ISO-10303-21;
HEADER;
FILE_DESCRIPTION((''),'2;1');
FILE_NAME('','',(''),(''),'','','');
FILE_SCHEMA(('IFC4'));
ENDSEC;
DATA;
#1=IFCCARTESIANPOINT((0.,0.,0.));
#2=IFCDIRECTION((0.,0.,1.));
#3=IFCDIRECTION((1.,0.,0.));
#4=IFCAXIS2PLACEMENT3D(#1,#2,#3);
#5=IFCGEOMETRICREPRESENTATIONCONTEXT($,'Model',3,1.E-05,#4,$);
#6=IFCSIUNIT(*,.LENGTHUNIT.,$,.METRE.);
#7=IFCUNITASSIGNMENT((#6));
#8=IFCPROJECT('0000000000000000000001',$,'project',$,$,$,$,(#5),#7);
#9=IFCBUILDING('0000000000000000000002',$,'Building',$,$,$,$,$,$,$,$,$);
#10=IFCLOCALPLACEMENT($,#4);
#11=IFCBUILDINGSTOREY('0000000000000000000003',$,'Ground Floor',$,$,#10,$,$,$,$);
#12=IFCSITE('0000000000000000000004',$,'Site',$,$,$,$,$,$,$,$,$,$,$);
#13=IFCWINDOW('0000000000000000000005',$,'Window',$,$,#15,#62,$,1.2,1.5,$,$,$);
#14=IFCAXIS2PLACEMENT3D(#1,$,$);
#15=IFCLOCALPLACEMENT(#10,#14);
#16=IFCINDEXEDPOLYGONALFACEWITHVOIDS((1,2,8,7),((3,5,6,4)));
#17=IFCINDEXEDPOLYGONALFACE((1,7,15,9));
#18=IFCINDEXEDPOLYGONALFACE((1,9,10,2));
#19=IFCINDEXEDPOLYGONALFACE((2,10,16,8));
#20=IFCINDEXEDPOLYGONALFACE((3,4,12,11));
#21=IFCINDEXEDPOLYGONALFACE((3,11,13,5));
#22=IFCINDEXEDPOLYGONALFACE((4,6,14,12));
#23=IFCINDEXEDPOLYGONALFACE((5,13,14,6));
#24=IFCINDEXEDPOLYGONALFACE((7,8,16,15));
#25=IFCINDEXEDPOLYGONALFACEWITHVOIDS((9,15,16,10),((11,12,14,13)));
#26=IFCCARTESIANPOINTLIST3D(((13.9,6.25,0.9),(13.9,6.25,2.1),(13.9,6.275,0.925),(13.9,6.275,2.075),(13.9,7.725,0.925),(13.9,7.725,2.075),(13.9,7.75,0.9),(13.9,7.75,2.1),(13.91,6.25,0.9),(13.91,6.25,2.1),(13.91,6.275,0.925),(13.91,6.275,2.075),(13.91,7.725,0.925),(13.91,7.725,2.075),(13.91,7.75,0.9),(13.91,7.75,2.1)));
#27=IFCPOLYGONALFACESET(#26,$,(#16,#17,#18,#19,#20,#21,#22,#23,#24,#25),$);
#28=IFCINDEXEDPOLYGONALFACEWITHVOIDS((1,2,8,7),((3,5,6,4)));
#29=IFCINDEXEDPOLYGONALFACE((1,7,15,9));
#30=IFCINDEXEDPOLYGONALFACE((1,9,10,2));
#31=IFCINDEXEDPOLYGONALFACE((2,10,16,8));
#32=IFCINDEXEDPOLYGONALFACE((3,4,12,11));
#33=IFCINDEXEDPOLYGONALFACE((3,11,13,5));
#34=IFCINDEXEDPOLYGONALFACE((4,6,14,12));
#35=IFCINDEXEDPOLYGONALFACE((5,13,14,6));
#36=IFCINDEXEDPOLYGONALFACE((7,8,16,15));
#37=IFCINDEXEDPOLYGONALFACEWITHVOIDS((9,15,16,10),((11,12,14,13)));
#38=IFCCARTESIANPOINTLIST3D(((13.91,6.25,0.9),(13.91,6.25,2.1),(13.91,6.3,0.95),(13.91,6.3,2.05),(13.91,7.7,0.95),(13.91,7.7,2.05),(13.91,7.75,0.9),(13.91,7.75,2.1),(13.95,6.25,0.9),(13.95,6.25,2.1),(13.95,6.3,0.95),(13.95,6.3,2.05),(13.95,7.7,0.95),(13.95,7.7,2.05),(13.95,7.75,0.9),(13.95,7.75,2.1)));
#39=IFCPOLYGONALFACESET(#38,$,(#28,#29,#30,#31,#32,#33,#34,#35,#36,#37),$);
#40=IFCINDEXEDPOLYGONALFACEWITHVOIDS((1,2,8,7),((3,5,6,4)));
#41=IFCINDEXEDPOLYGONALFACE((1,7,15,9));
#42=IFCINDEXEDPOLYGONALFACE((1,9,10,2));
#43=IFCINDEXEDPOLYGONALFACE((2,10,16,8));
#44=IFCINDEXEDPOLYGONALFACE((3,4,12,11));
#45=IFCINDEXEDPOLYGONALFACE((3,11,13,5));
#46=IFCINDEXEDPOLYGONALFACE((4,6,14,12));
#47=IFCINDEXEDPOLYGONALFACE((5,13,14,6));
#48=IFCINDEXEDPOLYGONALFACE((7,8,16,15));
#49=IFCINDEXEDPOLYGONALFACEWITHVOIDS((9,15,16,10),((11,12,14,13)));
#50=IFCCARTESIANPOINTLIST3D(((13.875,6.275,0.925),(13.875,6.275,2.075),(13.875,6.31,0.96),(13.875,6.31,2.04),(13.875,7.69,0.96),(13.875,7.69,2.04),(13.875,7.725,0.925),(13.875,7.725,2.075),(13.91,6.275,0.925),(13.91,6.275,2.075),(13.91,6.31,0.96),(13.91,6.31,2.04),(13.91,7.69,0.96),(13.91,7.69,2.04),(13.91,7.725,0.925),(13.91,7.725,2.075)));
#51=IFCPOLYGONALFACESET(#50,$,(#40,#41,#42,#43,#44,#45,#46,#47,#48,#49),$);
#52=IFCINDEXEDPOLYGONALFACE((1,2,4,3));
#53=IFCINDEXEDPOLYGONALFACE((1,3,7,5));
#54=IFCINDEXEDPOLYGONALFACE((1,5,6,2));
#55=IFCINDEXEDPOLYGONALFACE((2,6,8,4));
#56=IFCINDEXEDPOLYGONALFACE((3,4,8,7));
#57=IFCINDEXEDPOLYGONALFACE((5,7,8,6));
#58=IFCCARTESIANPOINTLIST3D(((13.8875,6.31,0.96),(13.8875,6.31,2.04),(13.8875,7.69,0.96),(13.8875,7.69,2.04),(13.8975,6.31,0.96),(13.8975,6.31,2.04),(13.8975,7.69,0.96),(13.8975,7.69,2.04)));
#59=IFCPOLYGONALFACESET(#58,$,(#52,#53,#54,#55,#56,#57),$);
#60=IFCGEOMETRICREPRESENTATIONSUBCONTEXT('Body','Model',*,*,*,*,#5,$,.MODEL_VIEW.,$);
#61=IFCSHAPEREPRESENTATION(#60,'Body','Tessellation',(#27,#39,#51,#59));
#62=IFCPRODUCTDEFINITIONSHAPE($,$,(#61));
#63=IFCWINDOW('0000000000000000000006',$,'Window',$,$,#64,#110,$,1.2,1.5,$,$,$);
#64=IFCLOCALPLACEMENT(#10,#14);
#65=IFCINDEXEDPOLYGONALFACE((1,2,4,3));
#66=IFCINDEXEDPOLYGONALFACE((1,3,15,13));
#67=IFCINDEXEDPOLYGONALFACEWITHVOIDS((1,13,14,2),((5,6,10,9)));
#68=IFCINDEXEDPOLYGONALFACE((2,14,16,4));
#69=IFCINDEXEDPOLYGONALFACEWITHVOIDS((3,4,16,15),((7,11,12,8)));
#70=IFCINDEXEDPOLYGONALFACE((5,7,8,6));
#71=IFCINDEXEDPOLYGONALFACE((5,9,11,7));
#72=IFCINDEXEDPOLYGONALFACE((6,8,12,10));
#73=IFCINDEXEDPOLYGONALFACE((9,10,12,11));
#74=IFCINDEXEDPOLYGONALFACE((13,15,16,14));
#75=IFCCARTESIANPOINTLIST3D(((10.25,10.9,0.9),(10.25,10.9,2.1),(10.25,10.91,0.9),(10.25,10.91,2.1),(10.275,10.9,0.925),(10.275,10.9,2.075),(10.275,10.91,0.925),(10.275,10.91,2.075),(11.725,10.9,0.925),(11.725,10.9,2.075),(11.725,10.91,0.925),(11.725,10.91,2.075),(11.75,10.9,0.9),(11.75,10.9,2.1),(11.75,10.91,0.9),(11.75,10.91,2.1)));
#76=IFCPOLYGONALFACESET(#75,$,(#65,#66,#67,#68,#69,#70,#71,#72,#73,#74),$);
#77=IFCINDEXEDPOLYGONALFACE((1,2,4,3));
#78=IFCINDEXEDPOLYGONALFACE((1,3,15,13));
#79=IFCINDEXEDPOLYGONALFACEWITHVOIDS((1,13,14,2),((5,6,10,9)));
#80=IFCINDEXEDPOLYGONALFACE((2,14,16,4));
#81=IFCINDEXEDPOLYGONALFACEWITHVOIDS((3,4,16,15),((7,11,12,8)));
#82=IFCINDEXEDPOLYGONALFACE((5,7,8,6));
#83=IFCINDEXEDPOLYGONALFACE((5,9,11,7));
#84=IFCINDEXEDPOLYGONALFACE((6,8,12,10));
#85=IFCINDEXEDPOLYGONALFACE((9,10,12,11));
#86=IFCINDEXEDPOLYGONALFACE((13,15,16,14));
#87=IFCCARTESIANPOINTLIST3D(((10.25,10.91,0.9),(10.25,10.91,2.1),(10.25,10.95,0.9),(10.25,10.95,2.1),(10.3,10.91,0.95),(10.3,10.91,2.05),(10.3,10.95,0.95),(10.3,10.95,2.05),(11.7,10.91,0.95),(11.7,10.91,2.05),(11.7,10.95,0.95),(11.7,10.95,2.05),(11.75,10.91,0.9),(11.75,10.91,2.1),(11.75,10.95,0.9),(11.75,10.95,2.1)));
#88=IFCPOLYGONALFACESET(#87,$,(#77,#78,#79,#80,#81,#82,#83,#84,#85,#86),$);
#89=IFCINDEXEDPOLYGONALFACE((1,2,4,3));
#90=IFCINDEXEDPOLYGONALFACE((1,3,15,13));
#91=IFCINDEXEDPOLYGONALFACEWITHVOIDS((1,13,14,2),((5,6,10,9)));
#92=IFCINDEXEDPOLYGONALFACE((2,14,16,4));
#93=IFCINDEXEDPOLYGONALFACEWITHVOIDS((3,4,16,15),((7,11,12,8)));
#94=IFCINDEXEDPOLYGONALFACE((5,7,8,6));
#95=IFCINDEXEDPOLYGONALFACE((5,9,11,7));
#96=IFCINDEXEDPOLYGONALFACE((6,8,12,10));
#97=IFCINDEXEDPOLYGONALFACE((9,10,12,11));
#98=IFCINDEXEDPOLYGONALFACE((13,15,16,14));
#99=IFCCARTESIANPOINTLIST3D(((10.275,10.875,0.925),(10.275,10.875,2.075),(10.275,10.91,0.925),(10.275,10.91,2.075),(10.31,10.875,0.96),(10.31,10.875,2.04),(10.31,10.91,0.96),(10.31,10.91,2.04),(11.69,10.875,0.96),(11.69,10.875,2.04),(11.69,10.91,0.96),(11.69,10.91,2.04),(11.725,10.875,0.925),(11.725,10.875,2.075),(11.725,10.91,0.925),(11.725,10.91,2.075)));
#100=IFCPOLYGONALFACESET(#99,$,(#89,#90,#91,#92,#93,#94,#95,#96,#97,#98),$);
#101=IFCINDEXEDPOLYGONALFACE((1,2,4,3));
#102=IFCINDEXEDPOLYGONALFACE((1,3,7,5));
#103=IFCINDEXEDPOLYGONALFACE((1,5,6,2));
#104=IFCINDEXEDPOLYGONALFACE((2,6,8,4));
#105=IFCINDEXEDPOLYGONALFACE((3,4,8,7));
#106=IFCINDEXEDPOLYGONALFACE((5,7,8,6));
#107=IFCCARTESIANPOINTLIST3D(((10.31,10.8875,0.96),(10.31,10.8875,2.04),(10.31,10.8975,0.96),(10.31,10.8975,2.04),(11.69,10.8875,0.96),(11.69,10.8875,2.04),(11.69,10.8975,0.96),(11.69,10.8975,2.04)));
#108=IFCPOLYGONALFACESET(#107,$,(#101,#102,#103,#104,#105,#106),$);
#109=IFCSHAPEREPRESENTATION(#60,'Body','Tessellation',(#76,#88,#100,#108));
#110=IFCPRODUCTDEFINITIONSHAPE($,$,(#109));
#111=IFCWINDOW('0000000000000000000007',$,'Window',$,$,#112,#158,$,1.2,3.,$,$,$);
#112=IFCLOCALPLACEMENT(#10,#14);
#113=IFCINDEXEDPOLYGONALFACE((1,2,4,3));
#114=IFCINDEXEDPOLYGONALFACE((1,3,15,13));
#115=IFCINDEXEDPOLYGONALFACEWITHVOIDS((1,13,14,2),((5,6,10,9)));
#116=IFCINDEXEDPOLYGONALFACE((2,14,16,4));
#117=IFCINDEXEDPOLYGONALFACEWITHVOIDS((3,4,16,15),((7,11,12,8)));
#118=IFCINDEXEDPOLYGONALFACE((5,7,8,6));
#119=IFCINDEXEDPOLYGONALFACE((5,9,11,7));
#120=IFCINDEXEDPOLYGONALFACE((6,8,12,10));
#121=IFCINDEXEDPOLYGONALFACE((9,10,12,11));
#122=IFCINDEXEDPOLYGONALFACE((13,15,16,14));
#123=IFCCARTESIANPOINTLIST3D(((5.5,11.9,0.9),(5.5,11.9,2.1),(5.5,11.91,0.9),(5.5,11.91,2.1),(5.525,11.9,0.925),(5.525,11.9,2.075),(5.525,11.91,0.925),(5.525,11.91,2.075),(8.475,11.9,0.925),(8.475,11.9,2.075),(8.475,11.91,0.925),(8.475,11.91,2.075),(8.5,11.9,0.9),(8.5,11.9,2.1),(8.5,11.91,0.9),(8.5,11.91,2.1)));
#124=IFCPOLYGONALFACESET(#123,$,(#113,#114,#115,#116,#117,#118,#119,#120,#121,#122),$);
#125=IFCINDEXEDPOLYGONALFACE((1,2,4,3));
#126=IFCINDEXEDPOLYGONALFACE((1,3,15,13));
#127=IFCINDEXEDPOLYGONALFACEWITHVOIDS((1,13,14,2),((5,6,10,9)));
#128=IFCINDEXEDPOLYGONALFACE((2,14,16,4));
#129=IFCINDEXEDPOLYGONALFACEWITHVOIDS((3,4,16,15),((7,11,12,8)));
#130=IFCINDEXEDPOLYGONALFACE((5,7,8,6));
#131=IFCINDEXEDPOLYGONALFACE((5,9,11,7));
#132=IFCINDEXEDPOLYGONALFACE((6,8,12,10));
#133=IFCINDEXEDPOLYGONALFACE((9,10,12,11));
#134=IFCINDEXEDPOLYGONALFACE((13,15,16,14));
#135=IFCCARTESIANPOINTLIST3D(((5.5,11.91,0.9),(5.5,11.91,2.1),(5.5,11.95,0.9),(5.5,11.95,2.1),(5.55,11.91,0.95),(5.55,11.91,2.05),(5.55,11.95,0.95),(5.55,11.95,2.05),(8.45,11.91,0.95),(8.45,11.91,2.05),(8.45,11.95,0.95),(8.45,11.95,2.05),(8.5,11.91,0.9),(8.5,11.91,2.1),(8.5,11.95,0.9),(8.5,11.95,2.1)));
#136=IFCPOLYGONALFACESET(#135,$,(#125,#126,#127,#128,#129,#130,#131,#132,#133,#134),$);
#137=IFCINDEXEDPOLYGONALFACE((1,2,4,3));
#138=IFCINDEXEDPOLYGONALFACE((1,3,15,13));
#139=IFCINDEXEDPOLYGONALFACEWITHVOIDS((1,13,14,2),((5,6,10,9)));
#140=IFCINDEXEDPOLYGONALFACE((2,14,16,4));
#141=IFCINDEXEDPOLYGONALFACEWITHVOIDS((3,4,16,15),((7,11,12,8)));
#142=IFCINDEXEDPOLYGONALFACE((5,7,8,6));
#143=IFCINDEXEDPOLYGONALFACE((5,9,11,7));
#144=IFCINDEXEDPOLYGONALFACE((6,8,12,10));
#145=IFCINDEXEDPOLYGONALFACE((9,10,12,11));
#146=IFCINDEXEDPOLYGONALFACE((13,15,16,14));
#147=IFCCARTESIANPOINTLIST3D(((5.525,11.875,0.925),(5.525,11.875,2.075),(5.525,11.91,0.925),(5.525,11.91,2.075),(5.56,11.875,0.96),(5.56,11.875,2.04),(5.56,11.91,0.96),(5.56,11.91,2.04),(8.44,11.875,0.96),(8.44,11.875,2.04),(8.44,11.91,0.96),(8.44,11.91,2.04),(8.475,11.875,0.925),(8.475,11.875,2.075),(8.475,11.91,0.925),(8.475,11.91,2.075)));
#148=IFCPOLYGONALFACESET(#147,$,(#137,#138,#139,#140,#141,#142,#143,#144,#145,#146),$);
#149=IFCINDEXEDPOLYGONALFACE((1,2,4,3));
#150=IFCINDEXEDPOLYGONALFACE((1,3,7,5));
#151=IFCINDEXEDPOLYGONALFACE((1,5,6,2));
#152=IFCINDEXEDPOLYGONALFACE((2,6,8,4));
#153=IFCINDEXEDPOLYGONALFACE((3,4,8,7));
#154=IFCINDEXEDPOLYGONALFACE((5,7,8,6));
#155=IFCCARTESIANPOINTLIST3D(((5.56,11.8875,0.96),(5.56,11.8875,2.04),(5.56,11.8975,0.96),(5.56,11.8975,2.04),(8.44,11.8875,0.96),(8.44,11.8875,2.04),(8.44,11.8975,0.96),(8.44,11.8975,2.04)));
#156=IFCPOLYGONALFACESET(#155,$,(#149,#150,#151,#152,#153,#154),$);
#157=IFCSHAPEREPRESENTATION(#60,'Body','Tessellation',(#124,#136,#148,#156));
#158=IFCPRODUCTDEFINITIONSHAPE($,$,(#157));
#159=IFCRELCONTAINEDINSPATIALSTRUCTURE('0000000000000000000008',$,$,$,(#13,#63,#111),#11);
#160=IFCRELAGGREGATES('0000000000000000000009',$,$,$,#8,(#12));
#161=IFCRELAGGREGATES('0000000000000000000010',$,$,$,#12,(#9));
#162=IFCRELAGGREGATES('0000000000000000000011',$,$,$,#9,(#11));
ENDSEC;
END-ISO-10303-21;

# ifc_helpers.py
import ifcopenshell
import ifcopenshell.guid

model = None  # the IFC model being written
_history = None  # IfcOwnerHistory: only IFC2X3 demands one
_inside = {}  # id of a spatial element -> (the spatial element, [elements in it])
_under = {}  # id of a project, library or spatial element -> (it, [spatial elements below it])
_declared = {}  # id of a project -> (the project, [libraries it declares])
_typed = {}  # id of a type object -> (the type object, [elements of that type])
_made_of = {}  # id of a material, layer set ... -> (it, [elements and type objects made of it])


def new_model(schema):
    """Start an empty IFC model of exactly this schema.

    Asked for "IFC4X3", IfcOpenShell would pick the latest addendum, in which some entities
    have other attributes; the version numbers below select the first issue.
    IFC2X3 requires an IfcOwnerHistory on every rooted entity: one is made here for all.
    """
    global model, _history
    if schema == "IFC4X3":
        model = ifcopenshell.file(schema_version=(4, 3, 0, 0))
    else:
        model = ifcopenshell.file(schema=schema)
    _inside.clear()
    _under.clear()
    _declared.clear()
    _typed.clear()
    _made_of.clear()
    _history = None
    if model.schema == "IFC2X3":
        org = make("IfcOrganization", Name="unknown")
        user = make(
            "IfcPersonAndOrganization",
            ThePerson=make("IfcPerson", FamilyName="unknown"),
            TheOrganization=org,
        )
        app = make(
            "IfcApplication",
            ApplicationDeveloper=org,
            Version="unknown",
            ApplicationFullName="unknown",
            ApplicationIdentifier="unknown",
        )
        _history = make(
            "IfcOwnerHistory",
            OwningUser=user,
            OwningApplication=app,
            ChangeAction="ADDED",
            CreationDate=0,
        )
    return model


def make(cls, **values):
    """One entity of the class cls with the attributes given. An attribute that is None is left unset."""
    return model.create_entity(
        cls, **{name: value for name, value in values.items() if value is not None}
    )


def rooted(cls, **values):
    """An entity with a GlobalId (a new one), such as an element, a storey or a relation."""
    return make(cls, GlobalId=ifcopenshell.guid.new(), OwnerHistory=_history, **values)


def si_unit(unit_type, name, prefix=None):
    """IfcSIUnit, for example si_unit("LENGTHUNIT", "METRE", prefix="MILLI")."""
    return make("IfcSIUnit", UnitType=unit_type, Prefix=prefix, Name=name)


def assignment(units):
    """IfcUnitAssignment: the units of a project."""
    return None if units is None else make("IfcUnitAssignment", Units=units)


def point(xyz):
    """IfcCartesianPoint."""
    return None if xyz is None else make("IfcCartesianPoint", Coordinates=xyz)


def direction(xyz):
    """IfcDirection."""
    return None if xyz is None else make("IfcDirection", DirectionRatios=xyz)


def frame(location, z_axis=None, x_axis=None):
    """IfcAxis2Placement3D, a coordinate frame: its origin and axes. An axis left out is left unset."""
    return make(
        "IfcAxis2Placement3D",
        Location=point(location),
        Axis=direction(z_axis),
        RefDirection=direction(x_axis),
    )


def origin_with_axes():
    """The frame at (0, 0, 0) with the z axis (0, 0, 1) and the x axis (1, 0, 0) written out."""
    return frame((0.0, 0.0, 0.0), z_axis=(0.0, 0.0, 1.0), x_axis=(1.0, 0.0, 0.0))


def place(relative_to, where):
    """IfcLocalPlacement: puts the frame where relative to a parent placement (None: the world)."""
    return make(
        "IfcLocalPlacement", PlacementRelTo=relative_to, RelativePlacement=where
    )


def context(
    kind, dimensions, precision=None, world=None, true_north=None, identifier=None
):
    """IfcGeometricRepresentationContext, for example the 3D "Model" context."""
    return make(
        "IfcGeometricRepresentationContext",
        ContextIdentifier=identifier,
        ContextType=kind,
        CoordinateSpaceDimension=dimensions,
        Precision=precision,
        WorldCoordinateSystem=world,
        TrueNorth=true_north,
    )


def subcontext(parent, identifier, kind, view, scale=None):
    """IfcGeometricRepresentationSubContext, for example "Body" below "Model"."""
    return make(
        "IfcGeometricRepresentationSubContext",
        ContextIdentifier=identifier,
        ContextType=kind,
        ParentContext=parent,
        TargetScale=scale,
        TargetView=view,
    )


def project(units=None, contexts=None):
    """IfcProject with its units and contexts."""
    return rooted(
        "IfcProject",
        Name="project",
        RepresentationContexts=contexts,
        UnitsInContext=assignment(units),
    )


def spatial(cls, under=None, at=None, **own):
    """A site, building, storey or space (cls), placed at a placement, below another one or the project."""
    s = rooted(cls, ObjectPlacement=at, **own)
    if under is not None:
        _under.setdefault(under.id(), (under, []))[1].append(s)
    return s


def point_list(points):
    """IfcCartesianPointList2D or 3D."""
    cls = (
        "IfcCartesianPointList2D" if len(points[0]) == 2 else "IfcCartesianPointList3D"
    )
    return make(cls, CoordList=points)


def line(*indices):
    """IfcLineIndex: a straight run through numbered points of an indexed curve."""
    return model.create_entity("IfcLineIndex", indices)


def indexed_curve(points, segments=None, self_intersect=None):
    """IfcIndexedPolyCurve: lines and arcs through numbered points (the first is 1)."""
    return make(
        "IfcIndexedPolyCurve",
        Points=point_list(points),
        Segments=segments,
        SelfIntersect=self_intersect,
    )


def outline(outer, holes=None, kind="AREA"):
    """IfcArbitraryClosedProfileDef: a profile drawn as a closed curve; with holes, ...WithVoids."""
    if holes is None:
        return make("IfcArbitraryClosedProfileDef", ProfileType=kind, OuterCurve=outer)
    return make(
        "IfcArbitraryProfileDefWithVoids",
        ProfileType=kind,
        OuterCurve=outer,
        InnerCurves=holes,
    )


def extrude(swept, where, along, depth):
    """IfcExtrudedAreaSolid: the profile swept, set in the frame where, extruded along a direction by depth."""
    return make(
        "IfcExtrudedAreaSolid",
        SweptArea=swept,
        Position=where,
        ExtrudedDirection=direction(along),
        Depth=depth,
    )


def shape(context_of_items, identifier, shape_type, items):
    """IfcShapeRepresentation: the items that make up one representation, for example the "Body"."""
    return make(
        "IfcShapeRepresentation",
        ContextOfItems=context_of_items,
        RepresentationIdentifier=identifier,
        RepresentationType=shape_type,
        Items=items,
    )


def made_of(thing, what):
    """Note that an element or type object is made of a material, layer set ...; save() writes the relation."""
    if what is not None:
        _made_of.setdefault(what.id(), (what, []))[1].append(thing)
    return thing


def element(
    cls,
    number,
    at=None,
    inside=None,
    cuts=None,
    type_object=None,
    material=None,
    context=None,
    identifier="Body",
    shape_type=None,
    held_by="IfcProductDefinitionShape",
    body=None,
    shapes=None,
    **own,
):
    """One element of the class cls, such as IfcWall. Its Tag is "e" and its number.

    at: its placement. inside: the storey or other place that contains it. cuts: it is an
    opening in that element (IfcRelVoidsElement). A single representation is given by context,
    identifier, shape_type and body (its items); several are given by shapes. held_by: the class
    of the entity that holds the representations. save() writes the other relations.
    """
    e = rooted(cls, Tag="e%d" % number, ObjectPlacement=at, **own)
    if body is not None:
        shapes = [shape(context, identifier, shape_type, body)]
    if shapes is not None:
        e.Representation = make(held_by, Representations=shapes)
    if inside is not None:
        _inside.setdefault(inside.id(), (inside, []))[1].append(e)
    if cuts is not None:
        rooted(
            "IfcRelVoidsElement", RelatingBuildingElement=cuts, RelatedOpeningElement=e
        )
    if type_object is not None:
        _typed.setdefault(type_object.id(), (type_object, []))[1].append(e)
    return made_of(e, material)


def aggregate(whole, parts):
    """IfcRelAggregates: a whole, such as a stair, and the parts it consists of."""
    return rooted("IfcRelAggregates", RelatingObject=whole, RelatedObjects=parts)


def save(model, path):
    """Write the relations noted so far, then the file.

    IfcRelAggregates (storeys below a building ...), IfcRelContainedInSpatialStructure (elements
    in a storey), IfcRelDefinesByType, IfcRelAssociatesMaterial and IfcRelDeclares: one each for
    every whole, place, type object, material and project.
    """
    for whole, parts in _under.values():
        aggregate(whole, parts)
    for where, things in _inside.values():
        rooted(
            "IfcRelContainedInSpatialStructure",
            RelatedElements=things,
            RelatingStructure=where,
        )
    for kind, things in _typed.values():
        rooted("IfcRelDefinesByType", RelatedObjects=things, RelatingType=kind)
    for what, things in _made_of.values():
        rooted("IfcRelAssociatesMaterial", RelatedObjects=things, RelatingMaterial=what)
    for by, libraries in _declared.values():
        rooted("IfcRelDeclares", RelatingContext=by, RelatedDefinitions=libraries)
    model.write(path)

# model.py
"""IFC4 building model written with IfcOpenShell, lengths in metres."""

from ifc_helpers import new_model, si_unit, frame, origin_with_axes, place, context, subcontext, project, spatial, line, indexed_curve, outline, extrude, element, save


model = new_model("IFC4")

# Units and contexts
model_context = context("Model", 3, precision=1e-05, world=origin_with_axes())
body_context = subcontext(model_context, "Body", "Model", "MODEL_VIEW")
ifc_project = project(units=[si_unit("LENGTHUNIT", "METRE")], contexts=[model_context])

# Site, building, storey
site = spatial("IfcSite", under=ifc_project, Name="Site")
building = spatial("IfcBuilding", under=site, Name="Building")
storey_placement = place(None, origin_with_axes())
storey = spatial("IfcBuildingStorey", under=building, at=storey_placement, Name="Ground Floor")

# Windows
for number, where, z_axis, x_axis, name in (
    (1, (14.0, 6.25, 0.9), (0.0, 0.0, 1.0), (0.0, 1.0, 0.0), "Window"),
    (2, (11.75, 11.0, 0.9), (0.0, 0.0, 1.0), (-1.0, 0.0, 0.0), "Window"),
):
    element("IfcWindow", number, at=place(storey_placement, frame(where, z_axis=z_axis, x_axis=x_axis)), inside=storey, Name=name, OverallHeight=1.2, OverallWidth=1.5, context=body_context, shape_type="SweptSolid", body=[
        extrude(outline(indexed_curve([(0.0, 0.0), (1.5, 0.0), (1.5, 1.2), (0.0, 1.2)], segments=[line(1, 2, 3, 4, 1)]), holes=[indexed_curve([(0.025, 0.025), (1.475, 0.025), (1.475, 1.175), (0.025, 1.175)], segments=[line(1, 2, 3, 4, 1)])]), frame((0.0, 0.09, 0.0), z_axis=(0.0, -1.0, 0.0), x_axis=(1.0, 0.0, 0.0)), (0.0, 0.0, -1.0), 0.01),
        extrude(outline(indexed_curve([(0.0, 0.0), (1.5, 0.0), (1.5, 1.2), (0.0, 1.2)], segments=[line(1, 2, 3, 4, 1)]), holes=[indexed_curve([(0.05, 0.05), (1.45, 0.05), (1.45, 1.15), (0.05, 1.15)], segments=[line(1, 2, 3, 4, 1)])]), frame((0.0, 0.05, 0.0), z_axis=(0.0, -1.0, 0.0), x_axis=(1.0, 0.0, 0.0)), (0.0, 0.0, -1.0), 0.04),
        extrude(outline(indexed_curve([(0.0, 0.0), (1.45, 0.0), (1.45, 1.15), (0.0, 1.15)], segments=[line(1, 2, 3, 4, 1)]), holes=[indexed_curve([(0.035, 0.035), (1.415, 0.035), (1.415, 1.115), (0.035, 1.115)], segments=[line(1, 2, 3, 4, 1)])]), frame((0.025, 0.09, 0.025), z_axis=(0.0, -1.0, 0.0), x_axis=(1.0, 0.0, 0.0)), (0.0, 0.0, -1.0), 0.035),
        extrude(outline(indexed_curve([(0.035, 0.035), (1.415, 0.035), (1.415, 1.115), (0.035, 1.115)], segments=[line(1, 2, 3, 4, 1)])), frame((0.025, 0.1025, 0.025), z_axis=(0.0, -1.0, 0.0), x_axis=(1.0, 0.0, 0.0)), (0.0, 0.0, -1.0), 0.01),
    ])
window_placement = place(storey_placement, frame((8.5, 12.0, 0.9), z_axis=(0.0, 0.0, 1.0), x_axis=(-1.0, 0.0, 0.0)))
element("IfcWindow", 3, at=window_placement, inside=storey, Name="Window", OverallHeight=1.2, OverallWidth=3.0, context=body_context, shape_type="SweptSolid", body=[
    extrude(outline(indexed_curve([(0.0, 0.0), (3.0, 0.0), (3.0, 1.2), (0.0, 1.2)], segments=[line(1, 2, 3, 4, 1)]), holes=[indexed_curve([(0.025, 0.025), (2.975, 0.025), (2.975, 1.175), (0.025, 1.175)], segments=[line(1, 2, 3, 4, 1)])]), frame((0.0, 0.09, 0.0), z_axis=(0.0, -1.0, 0.0), x_axis=(1.0, 0.0, 0.0)), (0.0, 0.0, -1.0), 0.01),
    extrude(outline(indexed_curve([(0.0, 0.0), (3.0, 0.0), (3.0, 1.2), (0.0, 1.2)], segments=[line(1, 2, 3, 4, 1)]), holes=[indexed_curve([(0.05, 0.05), (2.95, 0.05), (2.95, 1.15), (0.05, 1.15)], segments=[line(1, 2, 3, 4, 1)])]), frame((0.0, 0.05, 0.0), z_axis=(0.0, -1.0, 0.0), x_axis=(1.0, 0.0, 0.0)), (0.0, 0.0, -1.0), 0.04),
    extrude(outline(indexed_curve([(0.0, 0.0), (2.95, 0.0), (2.95, 1.15), (0.0, 1.15)], segments=[line(1, 2, 3, 4, 1)]), holes=[indexed_curve([(0.035, 0.035), (2.915, 0.035), (2.915, 1.115), (0.035, 1.115)], segments=[line(1, 2, 3, 4, 1)])]), frame((0.025, 0.09, 0.025), z_axis=(0.0, -1.0, 0.0), x_axis=(1.0, 0.0, 0.0)), (0.0, 0.0, -1.0), 0.035),
    extrude(outline(indexed_curve([(0.035, 0.035), (2.915, 0.035), (2.915, 1.115), (0.035, 1.115)], segments=[line(1, 2, 3, 4, 1)])), frame((0.025, 0.1025, 0.025), z_axis=(0.0, -1.0, 0.0), x_axis=(1.0, 0.0, 0.0)), (0.0, 0.0, -1.0), 0.01),
])

save(model, "model.ifc")
